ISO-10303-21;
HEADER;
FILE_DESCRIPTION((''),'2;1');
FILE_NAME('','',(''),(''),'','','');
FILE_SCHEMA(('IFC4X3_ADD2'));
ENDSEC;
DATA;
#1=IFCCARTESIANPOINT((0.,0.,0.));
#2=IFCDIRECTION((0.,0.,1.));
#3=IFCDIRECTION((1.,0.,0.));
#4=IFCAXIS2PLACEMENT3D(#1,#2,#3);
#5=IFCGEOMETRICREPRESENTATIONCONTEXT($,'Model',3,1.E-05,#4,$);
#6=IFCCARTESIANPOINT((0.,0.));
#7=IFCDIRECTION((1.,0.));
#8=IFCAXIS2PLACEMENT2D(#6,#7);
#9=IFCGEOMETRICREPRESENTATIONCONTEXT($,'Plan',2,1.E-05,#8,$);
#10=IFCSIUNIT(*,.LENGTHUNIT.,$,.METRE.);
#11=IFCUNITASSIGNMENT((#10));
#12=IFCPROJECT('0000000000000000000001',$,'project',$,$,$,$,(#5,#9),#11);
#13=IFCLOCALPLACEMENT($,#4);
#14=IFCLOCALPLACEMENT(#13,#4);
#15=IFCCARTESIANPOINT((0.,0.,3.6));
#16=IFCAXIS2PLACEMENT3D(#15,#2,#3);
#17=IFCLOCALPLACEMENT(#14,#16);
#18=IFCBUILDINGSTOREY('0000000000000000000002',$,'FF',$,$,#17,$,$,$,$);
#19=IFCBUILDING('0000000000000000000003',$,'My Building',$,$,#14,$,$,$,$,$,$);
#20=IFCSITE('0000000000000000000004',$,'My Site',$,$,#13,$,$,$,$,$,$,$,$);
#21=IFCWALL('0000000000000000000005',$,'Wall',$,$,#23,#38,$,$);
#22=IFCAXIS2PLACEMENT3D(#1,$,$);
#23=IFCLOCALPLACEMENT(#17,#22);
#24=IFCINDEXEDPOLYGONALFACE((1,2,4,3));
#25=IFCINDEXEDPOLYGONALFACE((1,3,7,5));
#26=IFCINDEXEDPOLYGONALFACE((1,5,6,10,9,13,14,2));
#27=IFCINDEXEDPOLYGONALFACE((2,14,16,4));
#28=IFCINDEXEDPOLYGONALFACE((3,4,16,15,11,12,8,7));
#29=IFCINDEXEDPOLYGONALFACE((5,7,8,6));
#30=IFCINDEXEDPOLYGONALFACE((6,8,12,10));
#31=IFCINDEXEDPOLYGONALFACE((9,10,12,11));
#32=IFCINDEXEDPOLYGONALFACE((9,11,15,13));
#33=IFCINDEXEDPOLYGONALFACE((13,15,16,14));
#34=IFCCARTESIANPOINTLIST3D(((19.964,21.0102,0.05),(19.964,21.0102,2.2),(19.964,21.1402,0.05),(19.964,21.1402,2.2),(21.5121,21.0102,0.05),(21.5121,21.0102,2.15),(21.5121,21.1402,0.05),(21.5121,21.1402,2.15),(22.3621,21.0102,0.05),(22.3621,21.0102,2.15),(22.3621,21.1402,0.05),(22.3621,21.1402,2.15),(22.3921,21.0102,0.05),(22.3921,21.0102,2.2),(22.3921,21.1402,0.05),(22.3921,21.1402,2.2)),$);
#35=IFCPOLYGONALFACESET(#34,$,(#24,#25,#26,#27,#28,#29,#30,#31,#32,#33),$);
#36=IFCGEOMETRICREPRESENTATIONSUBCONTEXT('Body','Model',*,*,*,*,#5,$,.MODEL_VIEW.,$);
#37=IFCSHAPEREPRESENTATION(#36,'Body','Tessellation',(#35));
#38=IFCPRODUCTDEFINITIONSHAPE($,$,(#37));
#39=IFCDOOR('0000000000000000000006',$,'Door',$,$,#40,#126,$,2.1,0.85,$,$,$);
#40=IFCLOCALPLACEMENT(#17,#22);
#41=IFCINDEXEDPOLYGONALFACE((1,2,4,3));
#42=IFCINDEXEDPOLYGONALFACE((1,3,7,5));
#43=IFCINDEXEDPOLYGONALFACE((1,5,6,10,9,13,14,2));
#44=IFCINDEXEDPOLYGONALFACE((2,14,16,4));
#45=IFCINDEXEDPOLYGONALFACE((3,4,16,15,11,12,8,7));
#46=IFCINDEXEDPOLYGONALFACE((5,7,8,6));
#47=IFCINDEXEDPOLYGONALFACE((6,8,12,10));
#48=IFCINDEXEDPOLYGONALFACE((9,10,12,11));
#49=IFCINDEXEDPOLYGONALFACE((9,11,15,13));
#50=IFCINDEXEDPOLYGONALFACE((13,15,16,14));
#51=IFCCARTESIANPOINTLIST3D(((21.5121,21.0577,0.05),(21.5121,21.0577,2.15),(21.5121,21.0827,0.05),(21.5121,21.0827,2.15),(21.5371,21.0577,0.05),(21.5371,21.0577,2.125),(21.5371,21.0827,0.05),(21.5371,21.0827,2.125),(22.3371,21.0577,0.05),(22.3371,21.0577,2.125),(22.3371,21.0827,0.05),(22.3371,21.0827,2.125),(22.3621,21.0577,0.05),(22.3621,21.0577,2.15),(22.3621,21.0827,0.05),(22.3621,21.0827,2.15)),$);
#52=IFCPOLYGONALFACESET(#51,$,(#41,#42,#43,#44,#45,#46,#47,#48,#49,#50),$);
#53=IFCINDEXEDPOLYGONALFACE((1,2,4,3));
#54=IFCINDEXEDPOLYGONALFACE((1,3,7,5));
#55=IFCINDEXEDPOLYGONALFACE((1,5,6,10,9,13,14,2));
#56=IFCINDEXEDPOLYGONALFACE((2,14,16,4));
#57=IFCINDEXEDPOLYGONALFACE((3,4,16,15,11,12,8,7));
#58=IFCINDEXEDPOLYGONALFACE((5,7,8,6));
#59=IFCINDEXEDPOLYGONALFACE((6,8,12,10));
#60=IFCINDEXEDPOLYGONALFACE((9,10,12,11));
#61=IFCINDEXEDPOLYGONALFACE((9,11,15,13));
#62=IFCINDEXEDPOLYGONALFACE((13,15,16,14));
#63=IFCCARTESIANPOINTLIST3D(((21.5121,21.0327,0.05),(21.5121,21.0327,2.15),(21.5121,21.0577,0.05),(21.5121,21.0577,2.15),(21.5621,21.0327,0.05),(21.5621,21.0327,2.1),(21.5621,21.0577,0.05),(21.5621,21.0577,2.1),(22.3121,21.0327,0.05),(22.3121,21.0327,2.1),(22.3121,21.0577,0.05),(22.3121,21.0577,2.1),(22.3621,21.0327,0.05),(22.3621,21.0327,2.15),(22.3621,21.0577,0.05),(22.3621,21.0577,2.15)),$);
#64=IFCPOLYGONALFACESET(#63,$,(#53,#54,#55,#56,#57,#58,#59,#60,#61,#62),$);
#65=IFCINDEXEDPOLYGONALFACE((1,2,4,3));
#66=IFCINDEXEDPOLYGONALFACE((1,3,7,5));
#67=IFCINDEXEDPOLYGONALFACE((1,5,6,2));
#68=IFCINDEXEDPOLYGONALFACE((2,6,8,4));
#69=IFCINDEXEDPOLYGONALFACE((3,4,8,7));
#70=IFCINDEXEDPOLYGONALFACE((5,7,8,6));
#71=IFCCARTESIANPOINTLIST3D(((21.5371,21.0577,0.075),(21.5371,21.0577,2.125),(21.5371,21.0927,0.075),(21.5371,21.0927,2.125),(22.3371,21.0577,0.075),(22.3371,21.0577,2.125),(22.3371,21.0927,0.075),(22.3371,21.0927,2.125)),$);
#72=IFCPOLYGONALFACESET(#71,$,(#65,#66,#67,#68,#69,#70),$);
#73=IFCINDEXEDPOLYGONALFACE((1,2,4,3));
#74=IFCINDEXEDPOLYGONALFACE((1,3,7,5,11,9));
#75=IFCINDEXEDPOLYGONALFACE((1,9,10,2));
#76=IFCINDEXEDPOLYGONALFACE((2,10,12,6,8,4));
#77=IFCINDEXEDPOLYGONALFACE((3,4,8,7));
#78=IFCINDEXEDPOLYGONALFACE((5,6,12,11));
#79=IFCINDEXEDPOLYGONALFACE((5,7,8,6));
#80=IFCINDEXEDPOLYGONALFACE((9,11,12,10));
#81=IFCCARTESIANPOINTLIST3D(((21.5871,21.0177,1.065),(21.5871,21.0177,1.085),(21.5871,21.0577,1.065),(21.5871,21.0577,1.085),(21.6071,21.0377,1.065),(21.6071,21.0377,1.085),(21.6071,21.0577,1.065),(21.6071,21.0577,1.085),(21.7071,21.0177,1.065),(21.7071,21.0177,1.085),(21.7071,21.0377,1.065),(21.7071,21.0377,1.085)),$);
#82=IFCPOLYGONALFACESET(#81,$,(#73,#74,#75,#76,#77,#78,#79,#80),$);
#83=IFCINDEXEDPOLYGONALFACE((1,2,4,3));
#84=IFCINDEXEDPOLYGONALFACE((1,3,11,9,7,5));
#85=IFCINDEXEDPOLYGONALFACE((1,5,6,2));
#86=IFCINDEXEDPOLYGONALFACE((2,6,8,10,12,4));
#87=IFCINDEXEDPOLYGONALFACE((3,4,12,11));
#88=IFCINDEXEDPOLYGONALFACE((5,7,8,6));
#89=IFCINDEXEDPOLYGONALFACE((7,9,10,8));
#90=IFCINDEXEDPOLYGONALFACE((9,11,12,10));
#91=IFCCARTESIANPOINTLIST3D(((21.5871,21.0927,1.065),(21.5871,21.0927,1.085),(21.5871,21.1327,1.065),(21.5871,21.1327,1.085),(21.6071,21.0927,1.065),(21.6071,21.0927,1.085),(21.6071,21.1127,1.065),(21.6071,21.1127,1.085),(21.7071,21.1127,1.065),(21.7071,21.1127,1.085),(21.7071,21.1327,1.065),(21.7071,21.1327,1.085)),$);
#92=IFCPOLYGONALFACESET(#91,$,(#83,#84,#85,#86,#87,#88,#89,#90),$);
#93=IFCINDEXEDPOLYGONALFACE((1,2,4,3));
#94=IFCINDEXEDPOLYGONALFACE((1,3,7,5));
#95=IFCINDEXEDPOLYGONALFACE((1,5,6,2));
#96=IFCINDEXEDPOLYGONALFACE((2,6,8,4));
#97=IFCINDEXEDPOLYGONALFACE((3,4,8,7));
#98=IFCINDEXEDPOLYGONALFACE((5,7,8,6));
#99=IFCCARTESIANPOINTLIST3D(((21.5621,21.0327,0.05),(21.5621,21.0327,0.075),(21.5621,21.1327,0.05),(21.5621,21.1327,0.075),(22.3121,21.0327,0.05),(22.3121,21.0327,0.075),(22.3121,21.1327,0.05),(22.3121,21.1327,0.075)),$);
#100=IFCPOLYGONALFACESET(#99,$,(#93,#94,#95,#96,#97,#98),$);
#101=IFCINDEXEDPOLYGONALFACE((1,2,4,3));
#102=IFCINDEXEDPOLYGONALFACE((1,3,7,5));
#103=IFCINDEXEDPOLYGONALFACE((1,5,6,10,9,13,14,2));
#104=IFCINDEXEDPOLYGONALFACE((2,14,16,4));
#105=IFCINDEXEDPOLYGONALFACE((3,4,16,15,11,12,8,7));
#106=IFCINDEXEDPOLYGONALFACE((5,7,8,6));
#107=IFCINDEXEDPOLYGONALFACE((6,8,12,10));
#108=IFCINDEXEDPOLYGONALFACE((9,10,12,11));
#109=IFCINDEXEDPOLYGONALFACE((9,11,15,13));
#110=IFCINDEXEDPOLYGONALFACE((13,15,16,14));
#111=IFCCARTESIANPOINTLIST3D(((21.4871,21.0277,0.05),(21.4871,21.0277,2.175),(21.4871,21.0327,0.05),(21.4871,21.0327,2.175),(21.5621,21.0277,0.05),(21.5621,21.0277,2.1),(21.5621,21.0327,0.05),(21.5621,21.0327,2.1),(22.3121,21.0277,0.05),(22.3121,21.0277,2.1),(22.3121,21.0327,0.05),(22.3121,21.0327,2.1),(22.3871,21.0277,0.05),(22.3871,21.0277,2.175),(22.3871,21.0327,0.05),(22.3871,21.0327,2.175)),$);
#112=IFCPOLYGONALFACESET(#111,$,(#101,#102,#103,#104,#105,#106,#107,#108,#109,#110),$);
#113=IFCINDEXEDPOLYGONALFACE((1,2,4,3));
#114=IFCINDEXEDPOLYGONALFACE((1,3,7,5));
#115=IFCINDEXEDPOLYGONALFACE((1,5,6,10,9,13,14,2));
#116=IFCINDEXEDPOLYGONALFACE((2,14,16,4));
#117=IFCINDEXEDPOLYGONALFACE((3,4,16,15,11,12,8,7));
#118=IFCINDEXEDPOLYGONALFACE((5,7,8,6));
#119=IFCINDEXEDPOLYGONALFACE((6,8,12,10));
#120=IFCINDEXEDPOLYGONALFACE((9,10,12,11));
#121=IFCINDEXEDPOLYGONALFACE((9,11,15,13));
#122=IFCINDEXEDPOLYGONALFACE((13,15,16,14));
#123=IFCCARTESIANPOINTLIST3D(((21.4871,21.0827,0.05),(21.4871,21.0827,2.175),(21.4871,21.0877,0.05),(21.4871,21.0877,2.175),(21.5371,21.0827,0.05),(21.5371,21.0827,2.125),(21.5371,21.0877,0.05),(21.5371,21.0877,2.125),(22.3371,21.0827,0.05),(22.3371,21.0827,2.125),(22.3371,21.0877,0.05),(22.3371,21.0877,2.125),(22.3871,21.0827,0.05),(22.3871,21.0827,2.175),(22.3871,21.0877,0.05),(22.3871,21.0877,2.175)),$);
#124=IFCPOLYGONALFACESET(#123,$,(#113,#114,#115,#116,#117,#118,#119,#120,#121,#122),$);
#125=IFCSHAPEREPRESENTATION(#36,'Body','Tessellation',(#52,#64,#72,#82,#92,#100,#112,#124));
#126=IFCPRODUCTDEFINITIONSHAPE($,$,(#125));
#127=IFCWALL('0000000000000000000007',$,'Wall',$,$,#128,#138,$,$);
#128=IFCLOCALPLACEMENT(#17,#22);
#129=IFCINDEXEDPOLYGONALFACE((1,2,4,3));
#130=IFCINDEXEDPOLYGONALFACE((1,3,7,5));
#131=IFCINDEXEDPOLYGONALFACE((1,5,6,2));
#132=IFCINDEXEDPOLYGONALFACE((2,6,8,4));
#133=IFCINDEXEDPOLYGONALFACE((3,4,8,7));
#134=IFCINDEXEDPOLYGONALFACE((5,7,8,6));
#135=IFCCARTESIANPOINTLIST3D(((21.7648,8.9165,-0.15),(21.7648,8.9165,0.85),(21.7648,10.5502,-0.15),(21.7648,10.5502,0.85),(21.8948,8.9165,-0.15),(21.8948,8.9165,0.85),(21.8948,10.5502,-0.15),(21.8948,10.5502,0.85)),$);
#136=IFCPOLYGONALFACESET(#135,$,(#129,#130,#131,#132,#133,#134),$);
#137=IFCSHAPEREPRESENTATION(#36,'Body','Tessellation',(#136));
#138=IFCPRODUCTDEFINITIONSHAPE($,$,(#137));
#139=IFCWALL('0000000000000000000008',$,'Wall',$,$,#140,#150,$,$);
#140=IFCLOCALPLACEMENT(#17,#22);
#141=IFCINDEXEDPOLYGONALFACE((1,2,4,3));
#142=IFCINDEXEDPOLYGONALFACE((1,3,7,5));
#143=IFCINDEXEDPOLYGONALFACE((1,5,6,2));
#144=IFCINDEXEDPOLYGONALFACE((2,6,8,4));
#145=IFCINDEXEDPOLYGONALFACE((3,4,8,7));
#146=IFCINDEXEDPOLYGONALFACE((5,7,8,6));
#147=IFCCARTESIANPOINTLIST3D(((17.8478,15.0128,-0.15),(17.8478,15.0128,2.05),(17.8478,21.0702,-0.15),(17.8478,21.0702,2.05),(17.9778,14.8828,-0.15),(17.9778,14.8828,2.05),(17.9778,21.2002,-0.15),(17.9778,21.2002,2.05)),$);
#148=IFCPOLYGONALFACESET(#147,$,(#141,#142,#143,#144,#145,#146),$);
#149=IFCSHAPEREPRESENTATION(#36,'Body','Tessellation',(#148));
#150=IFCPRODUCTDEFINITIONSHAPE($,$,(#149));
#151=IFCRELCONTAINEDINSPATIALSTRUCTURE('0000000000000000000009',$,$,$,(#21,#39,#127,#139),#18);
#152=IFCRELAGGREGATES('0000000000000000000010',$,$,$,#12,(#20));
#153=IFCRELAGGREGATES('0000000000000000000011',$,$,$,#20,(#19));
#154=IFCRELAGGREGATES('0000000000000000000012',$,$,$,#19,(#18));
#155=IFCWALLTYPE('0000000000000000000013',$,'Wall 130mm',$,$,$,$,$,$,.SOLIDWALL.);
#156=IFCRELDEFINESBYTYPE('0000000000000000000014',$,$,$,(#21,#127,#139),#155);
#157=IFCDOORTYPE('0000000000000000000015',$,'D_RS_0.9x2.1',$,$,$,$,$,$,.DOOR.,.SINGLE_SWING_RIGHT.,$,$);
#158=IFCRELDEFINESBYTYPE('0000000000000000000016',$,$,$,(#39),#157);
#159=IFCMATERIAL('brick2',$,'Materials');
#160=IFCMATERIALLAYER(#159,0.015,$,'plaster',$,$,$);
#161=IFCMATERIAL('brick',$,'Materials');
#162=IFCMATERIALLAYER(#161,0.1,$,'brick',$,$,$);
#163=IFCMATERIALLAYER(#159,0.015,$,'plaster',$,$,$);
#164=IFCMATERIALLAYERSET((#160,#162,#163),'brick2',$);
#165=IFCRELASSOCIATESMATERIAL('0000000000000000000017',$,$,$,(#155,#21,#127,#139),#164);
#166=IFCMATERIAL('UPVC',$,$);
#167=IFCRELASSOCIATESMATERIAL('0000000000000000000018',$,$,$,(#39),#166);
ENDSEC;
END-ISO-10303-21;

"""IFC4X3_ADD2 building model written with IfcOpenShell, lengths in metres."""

from ifc_helpers import new_model, entity, si_unit, frame, origin_with_axes, origin_2d_with_axis, place, context, subcontext, project, spatial, line, indexed_curve, outline, extrude, shape, source, transform, mapped, material, layer, layer_set, layer_usage, type_object, type_shapes, element, fill, save


model = new_model("IFC4X3_ADD2")

# Units and contexts
model_context = context("Model", 3, precision=1e-05, world=origin_with_axes())
plan_context = context("Plan", 2, precision=1e-05, world=origin_2d_with_axis())
body_context_1 = subcontext(model_context, "Body", "Model", "MODEL_VIEW")
body_context_2 = subcontext(plan_context, "Body", "Plan", "PLAN_VIEW")
ifc_project = project(units=[si_unit("LENGTHUNIT", "METRE")], contexts=[model_context, plan_context])

# Site, building, storey
site_placement = place(None, origin_with_axes())
site = spatial("IfcSite", under=ifc_project, at=site_placement, Name="My Site")
building_placement = place(site_placement, origin_with_axes())
building = spatial("IfcBuilding", under=site, at=building_placement, Name="My Building")
storey_placement = place(building_placement, frame((0.0, 0.0, 3.6), z_axis=(0.0, 0.0, 1.0), x_axis=(1.0, 0.0, 0.0)))
storey = spatial("IfcBuildingStorey", under=building, at=storey_placement, Name="FF")

# Shared definitions
ifc_material_1 = material(Name="UPVC")

# Shared definitions
ifc_material_2 = material(Name="brick2", Category="Materials")
ifc_material_3 = material(Name="brick", Category="Materials")

# Wall, opening, door
ifc_layer_1 = layer(ifc_material_2, 0.015, Name="plaster")
ifc_layer_2 = layer(ifc_material_3, 0.1, Name="brick")
ifc_layer_3 = layer(ifc_material_2, 0.015, Name="plaster")
ifc_layer_set_1 = layer_set([ifc_layer_1, ifc_layer_2, ifc_layer_3], Name="brick2")
ifc_layer_usage_1 = layer_usage(ifc_layer_set_1, "AXIS2", "POSITIVE", 0.0)
wall_type_1 = type_object("IfcWallType", Name="Wall 130mm", PredefinedType="SOLIDWALL", material=ifc_layer_set_1)
wall_1_placement = place(storey_placement, frame((22.6421, 21.1402, 0.05), z_axis=(0.0, 0.0, 1.0), x_axis=(-1.0, 0.0, 0.0)))
wall_1 = element("IfcWall", 1, at=wall_1_placement, inside=storey, type_object=wall_type_1, material=ifc_layer_usage_1, Name="Wall", context=body_context_1, shape_type="SweptSolid", body=[
    extrude(outline(indexed_curve([(0.25, 0.0), (0.25, 0.13), (2.6781, 0.13), (2.6781, 0.0)], segments=[line(1, 2, 3, 4, 1)])), origin_with_axes(), (0.0, 0.0, 1.0), 2.15),
])
shared_shape_1 = source(origin_with_axes(), body_context_1, "Body", "SweptSolid", [
    extrude(outline(indexed_curve([(0.0, 0.0), (0.85, 0.0), (0.85, 2.1), (0.0, 2.1)], segments=[line(1, 2, 3, 4, 1)])), frame((0.0, -0.6, 0.0), z_axis=(0.0, -1.0, 0.0), x_axis=(1.0, 0.0, 0.0)), (0.0, 0.0, -1.0), 1.2),
])
opening_1_placement = place(wall_1_placement, frame((1.13, 0.1075, 0.0), z_axis=(0.0, 0.0, 1.0), x_axis=(-1.0, 0.0, 0.0)))
opening_1 = element("IfcOpeningElement", 2, at=opening_1_placement, cuts=wall_1, PredefinedType="OPENING", context=body_context_1, shape_type="MappedRepresentation", body=[
    mapped(shared_shape_1, transform((0.0, 0.0, 0.0), x_axis=(1.0, 0.0, 0.0), y_axis=(0.0, 1.0, 0.0), z_axis=(0.0, 0.0, 1.0), scale=1.0)),
])
door_type = type_object("IfcDoorType", Name="D_RS_0.9x2.1", OperationType="SINGLE_SWING_RIGHT", PredefinedType="DOOR")
shared_shape_2 = source(origin_with_axes(), body_context_1, "Body", "SweptSolid", [
    extrude(outline(indexed_curve([(0.0, 0.0), (0.0, 2.1), (0.85, 2.1), (0.85, 0.0), (0.825, 0.0), (0.825, 2.075), (0.025, 2.075), (0.025, 0.0)], segments=[line(1, 2, 3, 4, 5, 6, 7, 8, 1)])), frame((0.0, 0.025, 0.0), z_axis=(0.0, -1.0, 0.0), x_axis=(1.0, 0.0, 0.0)), (0.0, 0.0, -1.0), 0.025),
    extrude(outline(indexed_curve([(0.0, 0.0), (0.0, 2.1), (0.85, 2.1), (0.85, 0.0), (0.8, 0.0), (0.8, 2.05), (0.05, 2.05), (0.05, 0.0)], segments=[line(1, 2, 3, 4, 5, 6, 7, 8, 1)])), frame((0.0, 0.0, 0.0), z_axis=(0.0, -1.0, 0.0), x_axis=(1.0, 0.0, 0.0)), (0.0, 0.0, -1.0), 0.025),
    extrude(outline(indexed_curve([(0.0, 0.0), (0.8, 0.0), (0.8, 0.035), (0.0, 0.035)], segments=[line(1, 2, 3, 4, 1)])), frame((0.025, 0.025, 0.025), z_axis=(0.0, 0.0, 1.0), x_axis=(1.0, 0.0, 0.0)), (0.0, 0.0, 1.0), 2.05),
    extrude(outline(indexed_curve([(0.0, 0.0), (0.0, -0.04), (0.12, -0.04), (0.12, -0.02), (0.02, -0.02), (0.02, 0.0)], segments=[line(1, 2, 3, 4, 5, 6, 1)])), frame((0.075, 0.025, 1.015), z_axis=(0.0, 0.0, 1.0), x_axis=(1.0, 0.0, 0.0)), (0.0, 0.0, 1.0), 0.02),
    extrude(outline(indexed_curve([(0.0, 0.0), (0.0, 0.04), (0.12, 0.04), (0.12, 0.02), (0.02, 0.02), (0.02, 0.0)], segments=[line(1, 2, 3, 4, 5, 6, 1)])), frame((0.075, 0.06, 1.015), z_axis=(0.0, 0.0, 1.0), x_axis=(1.0, 0.0, 0.0)), (0.0, 0.0, 1.0), 0.02),
    extrude(outline(indexed_curve([(0.0, 0.0), (0.75, 0.0), (0.75, 0.1), (0.0, 0.1)], segments=[line(1, 2, 3, 4, 1)])), frame((0.05, 0.0, 0.0), z_axis=(0.0, 0.0, 1.0), x_axis=(1.0, 0.0, 0.0)), (0.0, 0.0, 1.0), 0.025),
    extrude(outline(indexed_curve([(0.0, 0.0), (0.0, 2.125), (0.9, 2.125), (0.9, 0.0), (0.825, 0.0), (0.825, 2.05), (0.075, 2.05), (0.075, 0.0)], segments=[line(1, 2, 3, 4, 5, 6, 7, 8, 1)])), frame((-0.025, -0.005, 0.0), z_axis=(0.0, -1.0, 0.0), x_axis=(1.0, 0.0, 0.0)), (0.0, 0.0, -1.0), 0.005),
    extrude(outline(indexed_curve([(0.0, 0.0), (0.0, 2.125), (0.9, 2.125), (0.9, 0.0), (0.85, 0.0), (0.85, 2.075), (0.05, 2.075), (0.05, 0.0)], segments=[line(1, 2, 3, 4, 5, 6, 7, 8, 1)])), frame((-0.025, 0.05, 0.0), z_axis=(0.0, -1.0, 0.0), x_axis=(1.0, 0.0, 0.0)), (0.0, 0.0, -1.0), 0.005),
])
shared_shape_3 = source(origin_with_axes(), body_context_2, "Body", "Curve2D", [
    entity("IfcIndexedPolyCurve", entity("IfcCartesianPointList2D", [[0.0, 0.0], [0.0, 0.05], [0.025, 0.05], [0.025, 0.025], [0.05, 0.025], [0.05, 0.0]]), [entity("IfcLineIndex", [1, 2, 3, 4, 5, 6, 1])]),
    entity("IfcIndexedPolyCurve", entity("IfcCartesianPointList2D", [[0.85, 0.0], [0.85, 0.05], [0.825, 0.05], [0.825, 0.025], [0.8, 0.025], [0.8, 0.0]]), [entity("IfcLineIndex", [1, 2, 3, 4, 5, 6, 1])]),
    entity("IfcTrimmedCurve", entity("IfcEllipse", entity("IfcAxis2Placement2D", entity("IfcCartesianPoint", [0.79, 0.05]), entity("IfcDirection", [1.0, 0.0])), 0.765, 0.8), [entity("IfcCartesianPoint", [0.79, 0.85])], [entity("IfcCartesianPoint", [0.025, 0.05])], True, "CARTESIAN"),
    entity("IfcIndexedPolyCurve", entity("IfcCartesianPointList2D", [[0.825, 0.05], [0.79, 0.05], [0.79, 0.85], [0.825, 0.85]]), [entity("IfcLineIndex", [1, 2, 3, 4, 1])]),
])
type_shapes(door_type, [shared_shape_2, shared_shape_3])
door_placement = place(opening_1_placement, frame((0.0, 0.0, 0.0), z_axis=(0.0, 0.0, 1.0), x_axis=(1.0, 0.0, 0.0)))
door = element("IfcDoor", 3, at=door_placement, inside=storey, type_object=door_type, material=ifc_material_1, Name="Door", OverallHeight=2.1, OverallWidth=0.85, shapes=[
    shape(body_context_1, "Body", "MappedRepresentation", [mapped(shared_shape_2, transform((0.0, 0.0, 0.0), x_axis=(1.0, 0.0, 0.0), y_axis=(0.0, 1.0, 0.0), z_axis=(0.0, 0.0, 1.0), scale=1.0))]),
    shape(body_context_2, "Body", "MappedRepresentation", [mapped(shared_shape_3, transform((0.0, 0.0, 0.0), x_axis=(1.0, 0.0, 0.0), y_axis=(0.0, 1.0, 0.0), z_axis=(0.0, 0.0, 1.0), scale=1.0))]),
])
fill(opening_1, door)

# Walls
ifc_layer_usage_2 = layer_usage(ifc_layer_set_1, "AXIS2", "POSITIVE", 0.0)
wall_2_placement = place(storey_placement, frame((21.7648, 10.5502, -0.15), z_axis=(0.0, 0.0, 1.0), x_axis=(0.0, -1.0, 0.0)))
element("IfcWall", 4, at=wall_2_placement, inside=storey, type_object=wall_type_1, material=ifc_layer_usage_2, Name="Wall", context=body_context_1, shape_type="SweptSolid", body=[
    extrude(outline(indexed_curve([(0.0, 0.0), (0.0, 0.13), (1.6337, 0.13), (1.6337, 0.0)], segments=[line(1, 2, 3, 4, 1)])), origin_with_axes(), (0.0, 0.0, 1.0), 1.0),
])
ifc_layer_usage_3 = layer_usage(ifc_layer_set_1, "AXIS2", "POSITIVE", 0.0)
wall_3_placement = place(storey_placement, frame((17.9778, 15.0128, -0.15), z_axis=(0.0, 0.0, 1.0), x_axis=(0.000001, 1.0, 0.0)))
element("IfcWall", 5, at=wall_3_placement, inside=storey, type_object=wall_type_1, material=ifc_layer_usage_3, Name="Wall", context=body_context_1, shape_type="SweptSolid", body=[
    extrude(outline(indexed_curve([(-0.13, 0.0), (0.0, 0.13), (6.0575, 0.13), (6.1875, 0.0)], segments=[line(1, 2, 3, 4, 1)])), origin_with_axes(), (0.0, 0.0, 1.0), 2.2),
])

save(model, "model.ifc")
